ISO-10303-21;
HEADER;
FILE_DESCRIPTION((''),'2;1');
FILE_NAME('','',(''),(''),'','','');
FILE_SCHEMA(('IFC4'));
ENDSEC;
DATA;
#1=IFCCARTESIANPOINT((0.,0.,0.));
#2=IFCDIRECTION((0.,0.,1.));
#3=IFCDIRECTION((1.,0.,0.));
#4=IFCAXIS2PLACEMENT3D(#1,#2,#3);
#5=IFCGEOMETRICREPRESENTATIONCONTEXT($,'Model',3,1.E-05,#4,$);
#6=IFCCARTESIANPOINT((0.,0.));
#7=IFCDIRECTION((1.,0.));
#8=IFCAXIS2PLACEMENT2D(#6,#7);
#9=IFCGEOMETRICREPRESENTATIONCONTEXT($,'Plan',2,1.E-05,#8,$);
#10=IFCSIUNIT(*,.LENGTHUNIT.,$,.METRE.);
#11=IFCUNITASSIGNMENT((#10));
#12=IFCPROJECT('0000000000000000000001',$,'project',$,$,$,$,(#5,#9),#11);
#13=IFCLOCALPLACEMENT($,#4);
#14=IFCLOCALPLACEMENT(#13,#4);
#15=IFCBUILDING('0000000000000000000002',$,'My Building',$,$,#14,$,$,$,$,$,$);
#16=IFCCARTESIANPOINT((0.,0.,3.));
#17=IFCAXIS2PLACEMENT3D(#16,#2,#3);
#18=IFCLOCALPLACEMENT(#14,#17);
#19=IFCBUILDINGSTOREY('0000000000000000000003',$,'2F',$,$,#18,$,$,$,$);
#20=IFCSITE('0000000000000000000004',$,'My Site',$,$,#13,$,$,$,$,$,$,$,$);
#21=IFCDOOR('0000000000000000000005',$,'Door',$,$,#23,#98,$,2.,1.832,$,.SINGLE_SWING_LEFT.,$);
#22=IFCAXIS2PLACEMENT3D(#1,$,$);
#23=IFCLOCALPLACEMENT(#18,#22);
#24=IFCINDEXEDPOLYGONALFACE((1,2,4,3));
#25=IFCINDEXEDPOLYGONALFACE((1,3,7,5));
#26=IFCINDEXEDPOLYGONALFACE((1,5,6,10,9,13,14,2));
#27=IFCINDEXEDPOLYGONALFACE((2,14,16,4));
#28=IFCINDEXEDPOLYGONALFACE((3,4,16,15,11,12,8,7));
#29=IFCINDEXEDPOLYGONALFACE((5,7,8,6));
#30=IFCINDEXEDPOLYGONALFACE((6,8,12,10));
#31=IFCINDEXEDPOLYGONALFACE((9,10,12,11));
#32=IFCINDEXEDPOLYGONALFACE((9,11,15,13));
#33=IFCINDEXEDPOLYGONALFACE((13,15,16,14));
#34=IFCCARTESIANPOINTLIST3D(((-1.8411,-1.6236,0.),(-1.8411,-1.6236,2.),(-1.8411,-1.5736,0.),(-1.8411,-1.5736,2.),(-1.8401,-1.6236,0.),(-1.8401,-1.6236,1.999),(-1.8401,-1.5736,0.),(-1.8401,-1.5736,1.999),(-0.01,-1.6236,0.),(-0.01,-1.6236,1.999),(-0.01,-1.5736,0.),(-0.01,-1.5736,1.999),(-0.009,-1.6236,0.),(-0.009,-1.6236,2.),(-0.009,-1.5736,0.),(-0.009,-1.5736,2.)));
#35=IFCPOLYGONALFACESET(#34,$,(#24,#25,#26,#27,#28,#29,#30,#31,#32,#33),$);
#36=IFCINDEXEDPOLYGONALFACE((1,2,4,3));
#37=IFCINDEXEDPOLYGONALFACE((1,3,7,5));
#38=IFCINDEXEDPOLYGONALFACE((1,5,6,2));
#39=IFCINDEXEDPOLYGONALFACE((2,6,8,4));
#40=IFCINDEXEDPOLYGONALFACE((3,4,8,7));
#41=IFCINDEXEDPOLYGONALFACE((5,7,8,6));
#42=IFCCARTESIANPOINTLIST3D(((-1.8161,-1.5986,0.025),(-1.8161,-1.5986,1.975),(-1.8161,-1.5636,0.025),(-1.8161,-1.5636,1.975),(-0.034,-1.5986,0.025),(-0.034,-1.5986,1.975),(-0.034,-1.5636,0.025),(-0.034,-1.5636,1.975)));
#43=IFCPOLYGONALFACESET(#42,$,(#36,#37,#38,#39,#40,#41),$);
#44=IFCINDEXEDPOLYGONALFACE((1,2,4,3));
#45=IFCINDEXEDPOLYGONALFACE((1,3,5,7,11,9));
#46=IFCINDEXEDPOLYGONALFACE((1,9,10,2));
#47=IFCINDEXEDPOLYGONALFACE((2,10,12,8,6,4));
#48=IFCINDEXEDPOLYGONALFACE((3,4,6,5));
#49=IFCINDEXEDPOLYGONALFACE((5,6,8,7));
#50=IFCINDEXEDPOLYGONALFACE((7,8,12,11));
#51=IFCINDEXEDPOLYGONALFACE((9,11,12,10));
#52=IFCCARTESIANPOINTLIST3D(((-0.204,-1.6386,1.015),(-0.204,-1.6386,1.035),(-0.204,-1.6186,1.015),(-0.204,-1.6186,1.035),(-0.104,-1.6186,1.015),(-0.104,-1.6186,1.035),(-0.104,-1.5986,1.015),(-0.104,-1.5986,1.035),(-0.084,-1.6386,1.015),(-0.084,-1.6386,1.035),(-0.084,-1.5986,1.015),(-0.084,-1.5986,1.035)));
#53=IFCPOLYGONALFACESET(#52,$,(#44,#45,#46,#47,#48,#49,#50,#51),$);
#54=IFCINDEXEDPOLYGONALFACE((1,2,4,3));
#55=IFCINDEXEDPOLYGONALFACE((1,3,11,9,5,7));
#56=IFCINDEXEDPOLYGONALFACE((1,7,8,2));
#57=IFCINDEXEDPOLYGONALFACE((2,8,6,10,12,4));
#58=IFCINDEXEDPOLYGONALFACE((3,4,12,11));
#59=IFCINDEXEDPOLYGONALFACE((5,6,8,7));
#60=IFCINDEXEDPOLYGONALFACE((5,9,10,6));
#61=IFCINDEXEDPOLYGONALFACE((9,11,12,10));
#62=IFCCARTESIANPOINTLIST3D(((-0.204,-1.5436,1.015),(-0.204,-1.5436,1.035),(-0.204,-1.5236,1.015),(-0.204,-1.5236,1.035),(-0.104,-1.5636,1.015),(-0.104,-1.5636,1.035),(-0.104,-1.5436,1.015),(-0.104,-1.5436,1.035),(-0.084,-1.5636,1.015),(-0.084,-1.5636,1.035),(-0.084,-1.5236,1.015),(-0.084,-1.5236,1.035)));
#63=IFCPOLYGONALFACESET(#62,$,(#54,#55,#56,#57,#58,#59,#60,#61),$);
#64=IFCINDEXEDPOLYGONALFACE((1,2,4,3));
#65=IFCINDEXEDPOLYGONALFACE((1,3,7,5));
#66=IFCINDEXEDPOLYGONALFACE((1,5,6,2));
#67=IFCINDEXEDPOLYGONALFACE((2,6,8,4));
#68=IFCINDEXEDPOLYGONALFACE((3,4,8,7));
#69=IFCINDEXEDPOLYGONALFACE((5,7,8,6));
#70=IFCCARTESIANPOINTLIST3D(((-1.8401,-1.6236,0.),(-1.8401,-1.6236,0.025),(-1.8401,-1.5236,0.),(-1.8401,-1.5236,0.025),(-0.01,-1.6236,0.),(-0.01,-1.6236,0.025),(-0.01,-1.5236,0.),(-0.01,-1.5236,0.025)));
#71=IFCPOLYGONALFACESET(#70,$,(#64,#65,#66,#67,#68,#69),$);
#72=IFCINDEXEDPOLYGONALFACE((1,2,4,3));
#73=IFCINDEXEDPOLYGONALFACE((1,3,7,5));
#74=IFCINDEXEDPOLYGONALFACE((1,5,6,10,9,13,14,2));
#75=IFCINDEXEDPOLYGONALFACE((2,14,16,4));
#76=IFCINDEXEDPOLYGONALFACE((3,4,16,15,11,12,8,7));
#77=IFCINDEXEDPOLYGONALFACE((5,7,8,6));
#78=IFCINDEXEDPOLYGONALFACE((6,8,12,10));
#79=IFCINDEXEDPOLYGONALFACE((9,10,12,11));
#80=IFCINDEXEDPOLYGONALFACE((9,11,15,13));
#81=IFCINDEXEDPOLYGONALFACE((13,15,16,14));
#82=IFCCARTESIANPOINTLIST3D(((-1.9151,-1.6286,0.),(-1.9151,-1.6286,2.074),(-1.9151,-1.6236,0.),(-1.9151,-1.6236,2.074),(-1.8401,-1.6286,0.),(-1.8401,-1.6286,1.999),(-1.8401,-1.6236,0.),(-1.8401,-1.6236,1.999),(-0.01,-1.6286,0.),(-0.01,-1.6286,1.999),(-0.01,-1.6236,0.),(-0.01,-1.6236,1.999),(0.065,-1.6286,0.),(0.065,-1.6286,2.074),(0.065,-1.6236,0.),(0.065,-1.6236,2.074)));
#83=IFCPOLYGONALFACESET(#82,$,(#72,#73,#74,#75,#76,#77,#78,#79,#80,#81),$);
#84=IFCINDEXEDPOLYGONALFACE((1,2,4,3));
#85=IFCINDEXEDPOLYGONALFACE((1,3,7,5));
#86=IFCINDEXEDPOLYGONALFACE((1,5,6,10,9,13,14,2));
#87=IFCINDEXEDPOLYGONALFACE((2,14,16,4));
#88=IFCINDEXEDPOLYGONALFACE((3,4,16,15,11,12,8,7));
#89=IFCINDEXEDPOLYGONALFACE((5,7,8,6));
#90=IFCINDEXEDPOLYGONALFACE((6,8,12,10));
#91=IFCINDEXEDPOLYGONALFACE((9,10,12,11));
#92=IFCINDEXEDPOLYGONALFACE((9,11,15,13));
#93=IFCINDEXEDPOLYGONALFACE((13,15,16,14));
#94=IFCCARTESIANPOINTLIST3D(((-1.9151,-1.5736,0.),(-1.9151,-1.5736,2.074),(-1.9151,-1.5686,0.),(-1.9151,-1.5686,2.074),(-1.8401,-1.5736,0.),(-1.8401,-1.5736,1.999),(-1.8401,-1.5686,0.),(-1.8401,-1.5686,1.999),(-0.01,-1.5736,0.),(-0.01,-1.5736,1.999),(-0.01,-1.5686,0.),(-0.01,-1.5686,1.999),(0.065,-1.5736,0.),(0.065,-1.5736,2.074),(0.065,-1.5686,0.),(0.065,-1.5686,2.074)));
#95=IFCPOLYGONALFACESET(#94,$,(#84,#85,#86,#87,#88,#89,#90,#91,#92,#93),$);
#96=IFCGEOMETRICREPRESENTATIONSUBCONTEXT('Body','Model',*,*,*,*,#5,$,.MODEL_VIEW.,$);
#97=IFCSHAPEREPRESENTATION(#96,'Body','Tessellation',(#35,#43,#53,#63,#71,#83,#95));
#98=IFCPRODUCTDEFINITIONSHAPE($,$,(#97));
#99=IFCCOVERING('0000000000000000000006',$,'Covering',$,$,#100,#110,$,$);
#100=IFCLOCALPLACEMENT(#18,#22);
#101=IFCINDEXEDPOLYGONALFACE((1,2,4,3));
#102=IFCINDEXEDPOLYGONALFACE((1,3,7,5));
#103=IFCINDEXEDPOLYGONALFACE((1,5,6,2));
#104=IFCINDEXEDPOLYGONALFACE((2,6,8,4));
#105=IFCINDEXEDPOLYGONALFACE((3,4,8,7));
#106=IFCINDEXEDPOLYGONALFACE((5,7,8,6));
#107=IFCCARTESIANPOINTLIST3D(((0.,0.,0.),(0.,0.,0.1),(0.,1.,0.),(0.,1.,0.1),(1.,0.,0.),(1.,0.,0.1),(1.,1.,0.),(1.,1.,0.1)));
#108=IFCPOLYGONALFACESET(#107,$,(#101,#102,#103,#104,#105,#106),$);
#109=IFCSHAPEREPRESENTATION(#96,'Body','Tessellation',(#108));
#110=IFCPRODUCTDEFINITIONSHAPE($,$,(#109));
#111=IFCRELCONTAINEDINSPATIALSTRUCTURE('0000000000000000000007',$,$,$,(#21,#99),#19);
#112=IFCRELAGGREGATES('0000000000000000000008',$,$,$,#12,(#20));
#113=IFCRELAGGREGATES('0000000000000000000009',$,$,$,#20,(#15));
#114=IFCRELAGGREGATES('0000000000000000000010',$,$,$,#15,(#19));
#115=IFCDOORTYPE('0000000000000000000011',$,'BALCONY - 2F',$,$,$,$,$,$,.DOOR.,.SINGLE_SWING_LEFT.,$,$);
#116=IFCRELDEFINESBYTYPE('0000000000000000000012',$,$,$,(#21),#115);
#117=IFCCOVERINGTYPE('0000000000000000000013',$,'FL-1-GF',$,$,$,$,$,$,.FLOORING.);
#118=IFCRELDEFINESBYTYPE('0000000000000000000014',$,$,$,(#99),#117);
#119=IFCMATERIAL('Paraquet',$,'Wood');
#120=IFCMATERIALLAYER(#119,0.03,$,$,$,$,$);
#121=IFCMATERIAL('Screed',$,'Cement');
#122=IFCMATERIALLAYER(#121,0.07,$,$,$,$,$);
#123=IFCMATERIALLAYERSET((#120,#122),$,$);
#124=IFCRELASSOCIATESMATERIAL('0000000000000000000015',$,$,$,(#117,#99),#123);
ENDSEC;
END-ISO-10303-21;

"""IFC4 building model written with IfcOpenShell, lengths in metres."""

from ifc_helpers import new_model, entity, si_unit, frame, origin_with_axes, origin_2d_with_axis, place, context, subcontext, project, spatial, line, indexed_curve, outline, extrude, shape, source, transform, mapped, material, layer, layer_set, layer_usage, type_object, type_shapes, element, save


model = new_model("IFC4")

# Units and contexts
model_context = context("Model", 3, precision=1e-05, world=origin_with_axes())
plan_context = context("Plan", 2, precision=1e-05, world=origin_2d_with_axis())
body_context_1 = subcontext(model_context, "Body", "Model", "MODEL_VIEW")
body_context_2 = subcontext(plan_context, "Body", "Plan", "PLAN_VIEW")
ifc_project = project(units=[si_unit("LENGTHUNIT", "METRE")], contexts=[model_context, plan_context])

# Site, building, storey
site_placement = place(None, origin_with_axes())
site = spatial("IfcSite", under=ifc_project, at=site_placement, Name="My Site")
building_placement = place(site_placement, origin_with_axes())
building = spatial("IfcBuilding", under=site, at=building_placement, Name="My Building")
storey_placement = place(building_placement, frame((0.0, 0.0, 3.0), z_axis=(0.0, 0.0, 1.0), x_axis=(1.0, 0.0, 0.0)))
storey = spatial("IfcBuildingStorey", under=building, at=storey_placement, Name="2F")

# Door
door_type_1 = type_object("IfcDoorType", Name="BALCONY - 2F", OperationType="SINGLE_SWING_LEFT", PredefinedType="DOOR")
shared_shape_1 = source(origin_with_axes(), body_context_1, "Body", "SweptSolid", [
    extrude(outline(indexed_curve([(0.0, 0.0), (0.0, 2.0), (1.832, 2.0), (1.832, 0.0), (1.831, 0.0), (1.831, 1.999), (0.001, 1.999), (0.001, 0.0)], segments=[line(1, 2, 3, 4, 5, 6, 7, 8, 1)])), frame((0.0, 0.0, 0.0), z_axis=(0.0, -1.0, 0.0), x_axis=(1.0, 0.0, 0.0)), (0.0, 0.0, -1.0), 0.05),
    extrude(outline(indexed_curve([(0.0, 0.0), (1.782, 0.0), (1.782, 0.035), (0.0, 0.035)], segments=[line(1, 2, 3, 4, 1)])), frame((0.025, 0.025, 0.025), z_axis=(0.0, 0.0, 1.0), x_axis=(1.0, 0.0, 0.0)), (0.0, 0.0, 1.0), 1.95),
    extrude(outline(indexed_curve([(0.0, 0.0), (0.0, -0.04), (-0.12, -0.04), (-0.12, -0.02), (-0.02, -0.02), (-0.02, 0.0)], segments=[line(1, 2, 3, 4, 5, 6, 1)])), frame((1.757, 0.025, 1.015), z_axis=(0.0, 0.0, 1.0), x_axis=(1.0, 0.0, 0.0)), (0.0, 0.0, 1.0), 0.02),
    extrude(outline(indexed_curve([(0.0, 0.0), (0.0, 0.04), (-0.12, 0.04), (-0.12, 0.02), (-0.02, 0.02), (-0.02, 0.0)], segments=[line(1, 2, 3, 4, 5, 6, 1)])), frame((1.757, 0.06, 1.015), z_axis=(0.0, 0.0, 1.0), x_axis=(1.0, 0.0, 0.0)), (0.0, 0.0, 1.0), 0.02),
    extrude(outline(indexed_curve([(0.0, 0.0), (1.83, 0.0), (1.83, 0.1), (0.0, 0.1)], segments=[line(1, 2, 3, 4, 1)])), frame((0.001, 0.0, 0.0), z_axis=(0.0, 0.0, 1.0), x_axis=(1.0, 0.0, 0.0)), (0.0, 0.0, 1.0), 0.025),
    extrude(outline(indexed_curve([(0.0, 0.0), (0.0, 2.074), (1.98, 2.074), (1.98, 0.0), (1.905, 0.0), (1.905, 1.999), (0.075, 1.999), (0.075, 0.0)], segments=[line(1, 2, 3, 4, 5, 6, 7, 8, 1)])), frame((-0.074, -0.005, 0.0), z_axis=(0.0, -1.0, 0.0), x_axis=(1.0, 0.0, 0.0)), (0.0, 0.0, -1.0), 0.005),
    extrude(outline(indexed_curve([(0.0, 0.0), (0.0, 2.074), (1.98, 2.074), (1.98, 0.0), (1.905, 0.0), (1.905, 1.999), (0.075, 1.999), (0.075, 0.0)], segments=[line(1, 2, 3, 4, 5, 6, 7, 8, 1)])), frame((-0.074, 0.05, 0.0), z_axis=(0.0, -1.0, 0.0), x_axis=(1.0, 0.0, 0.0)), (0.0, 0.0, -1.0), 0.005),
])
shared_shape_2 = source(origin_with_axes(), body_context_2, "Body", "Curve2D", [
    entity("IfcIndexedPolyCurve", entity("IfcCartesianPointList2D", [[0.0, 0.0], [0.001, 0.0], [0.001, 0.05], [0.0, 0.05]]), [entity("IfcLineIndex", [1, 2, 3, 4, 1])]),
    entity("IfcIndexedPolyCurve", entity("IfcCartesianPointList2D", [[1.832, 0.0], [1.831, 0.0], [1.831, 0.05], [1.832, 0.05]]), [entity("IfcLineIndex", [1, 2, 3, 4, 1])]),
    entity("IfcTrimmedCurve", entity("IfcEllipse", entity("IfcAxis2Placement2D", entity("IfcCartesianPoint", [0.06, 0.05]), entity("IfcDirection", [1.0, 0.0])), 1.747, 1.782), [entity("IfcCartesianPoint", [1.807, 0.05])], [entity("IfcCartesianPoint", [0.06, 1.832])], True, "CARTESIAN"),
    entity("IfcIndexedPolyCurve", entity("IfcCartesianPointList2D", [[0.025, 0.05], [0.06, 0.05], [0.06, 1.832], [0.025, 1.832]]), [entity("IfcLineIndex", [1, 2, 3, 4, 1])]),
])
type_shapes(door_type_1, [shared_shape_1, shared_shape_2])
door_1_placement = place(storey_placement, frame((-1.8411, -1.6236, 0.0), z_axis=(0.0, 0.0, 1.0), x_axis=(1.0, 0.0, 0.0)))
element("IfcDoor", 1, at=door_1_placement, inside=storey, type_object=door_type_1, Name="Door", OperationType="SINGLE_SWING_LEFT", OverallHeight=2.0, OverallWidth=1.832, shapes=[
    shape(body_context_1, "Body", "MappedRepresentation", [mapped(shared_shape_1, transform((0.0, 0.0, 0.0), x_axis=(1.0, 0.0, 0.0), y_axis=(0.0, 1.0, 0.0), z_axis=(0.0, 0.0, 1.0), scale=1.0))]),
    shape(body_context_2, "Body", "MappedRepresentation", [mapped(shared_shape_2, transform((0.0, 0.0, 0.0), x_axis=(1.0, 0.0, 0.0), y_axis=(0.0, 1.0, 0.0), z_axis=(0.0, 0.0, 1.0), scale=1.0))]),
])

# Covering
ifc_material_1 = material(Name="Paraquet", Category="Wood")
ifc_layer_1 = layer(ifc_material_1, 0.03)
ifc_material_2 = material(Name="Screed", Category="Cement")
ifc_layer_2 = layer(ifc_material_2, 0.07)
ifc_layer_set_1 = layer_set([ifc_layer_1, ifc_layer_2])
ifc_layer_usage_1 = layer_usage(ifc_layer_set_1, "AXIS3", "POSITIVE", 0.0)
covering_type = type_object("IfcCoveringType", Name="FL-1-GF", PredefinedType="FLOORING", material=ifc_layer_set_1)
covering_1_placement = place(storey_placement, origin_with_axes())
element("IfcCovering", 2, at=covering_1_placement, inside=storey, type_object=covering_type, material=ifc_layer_usage_1, Name="Covering", context=body_context_1, shape_type="SweptSolid", body=[
    extrude(outline(indexed_curve([(0.0, 0.0), (1.0, 0.0), (1.0, 1.0), (0.0, 1.0), (0.0, 0.0)])), origin_with_axes(), (0.0, 0.0, 1.0), 0.1),
])

save(model, "model.ifc")
